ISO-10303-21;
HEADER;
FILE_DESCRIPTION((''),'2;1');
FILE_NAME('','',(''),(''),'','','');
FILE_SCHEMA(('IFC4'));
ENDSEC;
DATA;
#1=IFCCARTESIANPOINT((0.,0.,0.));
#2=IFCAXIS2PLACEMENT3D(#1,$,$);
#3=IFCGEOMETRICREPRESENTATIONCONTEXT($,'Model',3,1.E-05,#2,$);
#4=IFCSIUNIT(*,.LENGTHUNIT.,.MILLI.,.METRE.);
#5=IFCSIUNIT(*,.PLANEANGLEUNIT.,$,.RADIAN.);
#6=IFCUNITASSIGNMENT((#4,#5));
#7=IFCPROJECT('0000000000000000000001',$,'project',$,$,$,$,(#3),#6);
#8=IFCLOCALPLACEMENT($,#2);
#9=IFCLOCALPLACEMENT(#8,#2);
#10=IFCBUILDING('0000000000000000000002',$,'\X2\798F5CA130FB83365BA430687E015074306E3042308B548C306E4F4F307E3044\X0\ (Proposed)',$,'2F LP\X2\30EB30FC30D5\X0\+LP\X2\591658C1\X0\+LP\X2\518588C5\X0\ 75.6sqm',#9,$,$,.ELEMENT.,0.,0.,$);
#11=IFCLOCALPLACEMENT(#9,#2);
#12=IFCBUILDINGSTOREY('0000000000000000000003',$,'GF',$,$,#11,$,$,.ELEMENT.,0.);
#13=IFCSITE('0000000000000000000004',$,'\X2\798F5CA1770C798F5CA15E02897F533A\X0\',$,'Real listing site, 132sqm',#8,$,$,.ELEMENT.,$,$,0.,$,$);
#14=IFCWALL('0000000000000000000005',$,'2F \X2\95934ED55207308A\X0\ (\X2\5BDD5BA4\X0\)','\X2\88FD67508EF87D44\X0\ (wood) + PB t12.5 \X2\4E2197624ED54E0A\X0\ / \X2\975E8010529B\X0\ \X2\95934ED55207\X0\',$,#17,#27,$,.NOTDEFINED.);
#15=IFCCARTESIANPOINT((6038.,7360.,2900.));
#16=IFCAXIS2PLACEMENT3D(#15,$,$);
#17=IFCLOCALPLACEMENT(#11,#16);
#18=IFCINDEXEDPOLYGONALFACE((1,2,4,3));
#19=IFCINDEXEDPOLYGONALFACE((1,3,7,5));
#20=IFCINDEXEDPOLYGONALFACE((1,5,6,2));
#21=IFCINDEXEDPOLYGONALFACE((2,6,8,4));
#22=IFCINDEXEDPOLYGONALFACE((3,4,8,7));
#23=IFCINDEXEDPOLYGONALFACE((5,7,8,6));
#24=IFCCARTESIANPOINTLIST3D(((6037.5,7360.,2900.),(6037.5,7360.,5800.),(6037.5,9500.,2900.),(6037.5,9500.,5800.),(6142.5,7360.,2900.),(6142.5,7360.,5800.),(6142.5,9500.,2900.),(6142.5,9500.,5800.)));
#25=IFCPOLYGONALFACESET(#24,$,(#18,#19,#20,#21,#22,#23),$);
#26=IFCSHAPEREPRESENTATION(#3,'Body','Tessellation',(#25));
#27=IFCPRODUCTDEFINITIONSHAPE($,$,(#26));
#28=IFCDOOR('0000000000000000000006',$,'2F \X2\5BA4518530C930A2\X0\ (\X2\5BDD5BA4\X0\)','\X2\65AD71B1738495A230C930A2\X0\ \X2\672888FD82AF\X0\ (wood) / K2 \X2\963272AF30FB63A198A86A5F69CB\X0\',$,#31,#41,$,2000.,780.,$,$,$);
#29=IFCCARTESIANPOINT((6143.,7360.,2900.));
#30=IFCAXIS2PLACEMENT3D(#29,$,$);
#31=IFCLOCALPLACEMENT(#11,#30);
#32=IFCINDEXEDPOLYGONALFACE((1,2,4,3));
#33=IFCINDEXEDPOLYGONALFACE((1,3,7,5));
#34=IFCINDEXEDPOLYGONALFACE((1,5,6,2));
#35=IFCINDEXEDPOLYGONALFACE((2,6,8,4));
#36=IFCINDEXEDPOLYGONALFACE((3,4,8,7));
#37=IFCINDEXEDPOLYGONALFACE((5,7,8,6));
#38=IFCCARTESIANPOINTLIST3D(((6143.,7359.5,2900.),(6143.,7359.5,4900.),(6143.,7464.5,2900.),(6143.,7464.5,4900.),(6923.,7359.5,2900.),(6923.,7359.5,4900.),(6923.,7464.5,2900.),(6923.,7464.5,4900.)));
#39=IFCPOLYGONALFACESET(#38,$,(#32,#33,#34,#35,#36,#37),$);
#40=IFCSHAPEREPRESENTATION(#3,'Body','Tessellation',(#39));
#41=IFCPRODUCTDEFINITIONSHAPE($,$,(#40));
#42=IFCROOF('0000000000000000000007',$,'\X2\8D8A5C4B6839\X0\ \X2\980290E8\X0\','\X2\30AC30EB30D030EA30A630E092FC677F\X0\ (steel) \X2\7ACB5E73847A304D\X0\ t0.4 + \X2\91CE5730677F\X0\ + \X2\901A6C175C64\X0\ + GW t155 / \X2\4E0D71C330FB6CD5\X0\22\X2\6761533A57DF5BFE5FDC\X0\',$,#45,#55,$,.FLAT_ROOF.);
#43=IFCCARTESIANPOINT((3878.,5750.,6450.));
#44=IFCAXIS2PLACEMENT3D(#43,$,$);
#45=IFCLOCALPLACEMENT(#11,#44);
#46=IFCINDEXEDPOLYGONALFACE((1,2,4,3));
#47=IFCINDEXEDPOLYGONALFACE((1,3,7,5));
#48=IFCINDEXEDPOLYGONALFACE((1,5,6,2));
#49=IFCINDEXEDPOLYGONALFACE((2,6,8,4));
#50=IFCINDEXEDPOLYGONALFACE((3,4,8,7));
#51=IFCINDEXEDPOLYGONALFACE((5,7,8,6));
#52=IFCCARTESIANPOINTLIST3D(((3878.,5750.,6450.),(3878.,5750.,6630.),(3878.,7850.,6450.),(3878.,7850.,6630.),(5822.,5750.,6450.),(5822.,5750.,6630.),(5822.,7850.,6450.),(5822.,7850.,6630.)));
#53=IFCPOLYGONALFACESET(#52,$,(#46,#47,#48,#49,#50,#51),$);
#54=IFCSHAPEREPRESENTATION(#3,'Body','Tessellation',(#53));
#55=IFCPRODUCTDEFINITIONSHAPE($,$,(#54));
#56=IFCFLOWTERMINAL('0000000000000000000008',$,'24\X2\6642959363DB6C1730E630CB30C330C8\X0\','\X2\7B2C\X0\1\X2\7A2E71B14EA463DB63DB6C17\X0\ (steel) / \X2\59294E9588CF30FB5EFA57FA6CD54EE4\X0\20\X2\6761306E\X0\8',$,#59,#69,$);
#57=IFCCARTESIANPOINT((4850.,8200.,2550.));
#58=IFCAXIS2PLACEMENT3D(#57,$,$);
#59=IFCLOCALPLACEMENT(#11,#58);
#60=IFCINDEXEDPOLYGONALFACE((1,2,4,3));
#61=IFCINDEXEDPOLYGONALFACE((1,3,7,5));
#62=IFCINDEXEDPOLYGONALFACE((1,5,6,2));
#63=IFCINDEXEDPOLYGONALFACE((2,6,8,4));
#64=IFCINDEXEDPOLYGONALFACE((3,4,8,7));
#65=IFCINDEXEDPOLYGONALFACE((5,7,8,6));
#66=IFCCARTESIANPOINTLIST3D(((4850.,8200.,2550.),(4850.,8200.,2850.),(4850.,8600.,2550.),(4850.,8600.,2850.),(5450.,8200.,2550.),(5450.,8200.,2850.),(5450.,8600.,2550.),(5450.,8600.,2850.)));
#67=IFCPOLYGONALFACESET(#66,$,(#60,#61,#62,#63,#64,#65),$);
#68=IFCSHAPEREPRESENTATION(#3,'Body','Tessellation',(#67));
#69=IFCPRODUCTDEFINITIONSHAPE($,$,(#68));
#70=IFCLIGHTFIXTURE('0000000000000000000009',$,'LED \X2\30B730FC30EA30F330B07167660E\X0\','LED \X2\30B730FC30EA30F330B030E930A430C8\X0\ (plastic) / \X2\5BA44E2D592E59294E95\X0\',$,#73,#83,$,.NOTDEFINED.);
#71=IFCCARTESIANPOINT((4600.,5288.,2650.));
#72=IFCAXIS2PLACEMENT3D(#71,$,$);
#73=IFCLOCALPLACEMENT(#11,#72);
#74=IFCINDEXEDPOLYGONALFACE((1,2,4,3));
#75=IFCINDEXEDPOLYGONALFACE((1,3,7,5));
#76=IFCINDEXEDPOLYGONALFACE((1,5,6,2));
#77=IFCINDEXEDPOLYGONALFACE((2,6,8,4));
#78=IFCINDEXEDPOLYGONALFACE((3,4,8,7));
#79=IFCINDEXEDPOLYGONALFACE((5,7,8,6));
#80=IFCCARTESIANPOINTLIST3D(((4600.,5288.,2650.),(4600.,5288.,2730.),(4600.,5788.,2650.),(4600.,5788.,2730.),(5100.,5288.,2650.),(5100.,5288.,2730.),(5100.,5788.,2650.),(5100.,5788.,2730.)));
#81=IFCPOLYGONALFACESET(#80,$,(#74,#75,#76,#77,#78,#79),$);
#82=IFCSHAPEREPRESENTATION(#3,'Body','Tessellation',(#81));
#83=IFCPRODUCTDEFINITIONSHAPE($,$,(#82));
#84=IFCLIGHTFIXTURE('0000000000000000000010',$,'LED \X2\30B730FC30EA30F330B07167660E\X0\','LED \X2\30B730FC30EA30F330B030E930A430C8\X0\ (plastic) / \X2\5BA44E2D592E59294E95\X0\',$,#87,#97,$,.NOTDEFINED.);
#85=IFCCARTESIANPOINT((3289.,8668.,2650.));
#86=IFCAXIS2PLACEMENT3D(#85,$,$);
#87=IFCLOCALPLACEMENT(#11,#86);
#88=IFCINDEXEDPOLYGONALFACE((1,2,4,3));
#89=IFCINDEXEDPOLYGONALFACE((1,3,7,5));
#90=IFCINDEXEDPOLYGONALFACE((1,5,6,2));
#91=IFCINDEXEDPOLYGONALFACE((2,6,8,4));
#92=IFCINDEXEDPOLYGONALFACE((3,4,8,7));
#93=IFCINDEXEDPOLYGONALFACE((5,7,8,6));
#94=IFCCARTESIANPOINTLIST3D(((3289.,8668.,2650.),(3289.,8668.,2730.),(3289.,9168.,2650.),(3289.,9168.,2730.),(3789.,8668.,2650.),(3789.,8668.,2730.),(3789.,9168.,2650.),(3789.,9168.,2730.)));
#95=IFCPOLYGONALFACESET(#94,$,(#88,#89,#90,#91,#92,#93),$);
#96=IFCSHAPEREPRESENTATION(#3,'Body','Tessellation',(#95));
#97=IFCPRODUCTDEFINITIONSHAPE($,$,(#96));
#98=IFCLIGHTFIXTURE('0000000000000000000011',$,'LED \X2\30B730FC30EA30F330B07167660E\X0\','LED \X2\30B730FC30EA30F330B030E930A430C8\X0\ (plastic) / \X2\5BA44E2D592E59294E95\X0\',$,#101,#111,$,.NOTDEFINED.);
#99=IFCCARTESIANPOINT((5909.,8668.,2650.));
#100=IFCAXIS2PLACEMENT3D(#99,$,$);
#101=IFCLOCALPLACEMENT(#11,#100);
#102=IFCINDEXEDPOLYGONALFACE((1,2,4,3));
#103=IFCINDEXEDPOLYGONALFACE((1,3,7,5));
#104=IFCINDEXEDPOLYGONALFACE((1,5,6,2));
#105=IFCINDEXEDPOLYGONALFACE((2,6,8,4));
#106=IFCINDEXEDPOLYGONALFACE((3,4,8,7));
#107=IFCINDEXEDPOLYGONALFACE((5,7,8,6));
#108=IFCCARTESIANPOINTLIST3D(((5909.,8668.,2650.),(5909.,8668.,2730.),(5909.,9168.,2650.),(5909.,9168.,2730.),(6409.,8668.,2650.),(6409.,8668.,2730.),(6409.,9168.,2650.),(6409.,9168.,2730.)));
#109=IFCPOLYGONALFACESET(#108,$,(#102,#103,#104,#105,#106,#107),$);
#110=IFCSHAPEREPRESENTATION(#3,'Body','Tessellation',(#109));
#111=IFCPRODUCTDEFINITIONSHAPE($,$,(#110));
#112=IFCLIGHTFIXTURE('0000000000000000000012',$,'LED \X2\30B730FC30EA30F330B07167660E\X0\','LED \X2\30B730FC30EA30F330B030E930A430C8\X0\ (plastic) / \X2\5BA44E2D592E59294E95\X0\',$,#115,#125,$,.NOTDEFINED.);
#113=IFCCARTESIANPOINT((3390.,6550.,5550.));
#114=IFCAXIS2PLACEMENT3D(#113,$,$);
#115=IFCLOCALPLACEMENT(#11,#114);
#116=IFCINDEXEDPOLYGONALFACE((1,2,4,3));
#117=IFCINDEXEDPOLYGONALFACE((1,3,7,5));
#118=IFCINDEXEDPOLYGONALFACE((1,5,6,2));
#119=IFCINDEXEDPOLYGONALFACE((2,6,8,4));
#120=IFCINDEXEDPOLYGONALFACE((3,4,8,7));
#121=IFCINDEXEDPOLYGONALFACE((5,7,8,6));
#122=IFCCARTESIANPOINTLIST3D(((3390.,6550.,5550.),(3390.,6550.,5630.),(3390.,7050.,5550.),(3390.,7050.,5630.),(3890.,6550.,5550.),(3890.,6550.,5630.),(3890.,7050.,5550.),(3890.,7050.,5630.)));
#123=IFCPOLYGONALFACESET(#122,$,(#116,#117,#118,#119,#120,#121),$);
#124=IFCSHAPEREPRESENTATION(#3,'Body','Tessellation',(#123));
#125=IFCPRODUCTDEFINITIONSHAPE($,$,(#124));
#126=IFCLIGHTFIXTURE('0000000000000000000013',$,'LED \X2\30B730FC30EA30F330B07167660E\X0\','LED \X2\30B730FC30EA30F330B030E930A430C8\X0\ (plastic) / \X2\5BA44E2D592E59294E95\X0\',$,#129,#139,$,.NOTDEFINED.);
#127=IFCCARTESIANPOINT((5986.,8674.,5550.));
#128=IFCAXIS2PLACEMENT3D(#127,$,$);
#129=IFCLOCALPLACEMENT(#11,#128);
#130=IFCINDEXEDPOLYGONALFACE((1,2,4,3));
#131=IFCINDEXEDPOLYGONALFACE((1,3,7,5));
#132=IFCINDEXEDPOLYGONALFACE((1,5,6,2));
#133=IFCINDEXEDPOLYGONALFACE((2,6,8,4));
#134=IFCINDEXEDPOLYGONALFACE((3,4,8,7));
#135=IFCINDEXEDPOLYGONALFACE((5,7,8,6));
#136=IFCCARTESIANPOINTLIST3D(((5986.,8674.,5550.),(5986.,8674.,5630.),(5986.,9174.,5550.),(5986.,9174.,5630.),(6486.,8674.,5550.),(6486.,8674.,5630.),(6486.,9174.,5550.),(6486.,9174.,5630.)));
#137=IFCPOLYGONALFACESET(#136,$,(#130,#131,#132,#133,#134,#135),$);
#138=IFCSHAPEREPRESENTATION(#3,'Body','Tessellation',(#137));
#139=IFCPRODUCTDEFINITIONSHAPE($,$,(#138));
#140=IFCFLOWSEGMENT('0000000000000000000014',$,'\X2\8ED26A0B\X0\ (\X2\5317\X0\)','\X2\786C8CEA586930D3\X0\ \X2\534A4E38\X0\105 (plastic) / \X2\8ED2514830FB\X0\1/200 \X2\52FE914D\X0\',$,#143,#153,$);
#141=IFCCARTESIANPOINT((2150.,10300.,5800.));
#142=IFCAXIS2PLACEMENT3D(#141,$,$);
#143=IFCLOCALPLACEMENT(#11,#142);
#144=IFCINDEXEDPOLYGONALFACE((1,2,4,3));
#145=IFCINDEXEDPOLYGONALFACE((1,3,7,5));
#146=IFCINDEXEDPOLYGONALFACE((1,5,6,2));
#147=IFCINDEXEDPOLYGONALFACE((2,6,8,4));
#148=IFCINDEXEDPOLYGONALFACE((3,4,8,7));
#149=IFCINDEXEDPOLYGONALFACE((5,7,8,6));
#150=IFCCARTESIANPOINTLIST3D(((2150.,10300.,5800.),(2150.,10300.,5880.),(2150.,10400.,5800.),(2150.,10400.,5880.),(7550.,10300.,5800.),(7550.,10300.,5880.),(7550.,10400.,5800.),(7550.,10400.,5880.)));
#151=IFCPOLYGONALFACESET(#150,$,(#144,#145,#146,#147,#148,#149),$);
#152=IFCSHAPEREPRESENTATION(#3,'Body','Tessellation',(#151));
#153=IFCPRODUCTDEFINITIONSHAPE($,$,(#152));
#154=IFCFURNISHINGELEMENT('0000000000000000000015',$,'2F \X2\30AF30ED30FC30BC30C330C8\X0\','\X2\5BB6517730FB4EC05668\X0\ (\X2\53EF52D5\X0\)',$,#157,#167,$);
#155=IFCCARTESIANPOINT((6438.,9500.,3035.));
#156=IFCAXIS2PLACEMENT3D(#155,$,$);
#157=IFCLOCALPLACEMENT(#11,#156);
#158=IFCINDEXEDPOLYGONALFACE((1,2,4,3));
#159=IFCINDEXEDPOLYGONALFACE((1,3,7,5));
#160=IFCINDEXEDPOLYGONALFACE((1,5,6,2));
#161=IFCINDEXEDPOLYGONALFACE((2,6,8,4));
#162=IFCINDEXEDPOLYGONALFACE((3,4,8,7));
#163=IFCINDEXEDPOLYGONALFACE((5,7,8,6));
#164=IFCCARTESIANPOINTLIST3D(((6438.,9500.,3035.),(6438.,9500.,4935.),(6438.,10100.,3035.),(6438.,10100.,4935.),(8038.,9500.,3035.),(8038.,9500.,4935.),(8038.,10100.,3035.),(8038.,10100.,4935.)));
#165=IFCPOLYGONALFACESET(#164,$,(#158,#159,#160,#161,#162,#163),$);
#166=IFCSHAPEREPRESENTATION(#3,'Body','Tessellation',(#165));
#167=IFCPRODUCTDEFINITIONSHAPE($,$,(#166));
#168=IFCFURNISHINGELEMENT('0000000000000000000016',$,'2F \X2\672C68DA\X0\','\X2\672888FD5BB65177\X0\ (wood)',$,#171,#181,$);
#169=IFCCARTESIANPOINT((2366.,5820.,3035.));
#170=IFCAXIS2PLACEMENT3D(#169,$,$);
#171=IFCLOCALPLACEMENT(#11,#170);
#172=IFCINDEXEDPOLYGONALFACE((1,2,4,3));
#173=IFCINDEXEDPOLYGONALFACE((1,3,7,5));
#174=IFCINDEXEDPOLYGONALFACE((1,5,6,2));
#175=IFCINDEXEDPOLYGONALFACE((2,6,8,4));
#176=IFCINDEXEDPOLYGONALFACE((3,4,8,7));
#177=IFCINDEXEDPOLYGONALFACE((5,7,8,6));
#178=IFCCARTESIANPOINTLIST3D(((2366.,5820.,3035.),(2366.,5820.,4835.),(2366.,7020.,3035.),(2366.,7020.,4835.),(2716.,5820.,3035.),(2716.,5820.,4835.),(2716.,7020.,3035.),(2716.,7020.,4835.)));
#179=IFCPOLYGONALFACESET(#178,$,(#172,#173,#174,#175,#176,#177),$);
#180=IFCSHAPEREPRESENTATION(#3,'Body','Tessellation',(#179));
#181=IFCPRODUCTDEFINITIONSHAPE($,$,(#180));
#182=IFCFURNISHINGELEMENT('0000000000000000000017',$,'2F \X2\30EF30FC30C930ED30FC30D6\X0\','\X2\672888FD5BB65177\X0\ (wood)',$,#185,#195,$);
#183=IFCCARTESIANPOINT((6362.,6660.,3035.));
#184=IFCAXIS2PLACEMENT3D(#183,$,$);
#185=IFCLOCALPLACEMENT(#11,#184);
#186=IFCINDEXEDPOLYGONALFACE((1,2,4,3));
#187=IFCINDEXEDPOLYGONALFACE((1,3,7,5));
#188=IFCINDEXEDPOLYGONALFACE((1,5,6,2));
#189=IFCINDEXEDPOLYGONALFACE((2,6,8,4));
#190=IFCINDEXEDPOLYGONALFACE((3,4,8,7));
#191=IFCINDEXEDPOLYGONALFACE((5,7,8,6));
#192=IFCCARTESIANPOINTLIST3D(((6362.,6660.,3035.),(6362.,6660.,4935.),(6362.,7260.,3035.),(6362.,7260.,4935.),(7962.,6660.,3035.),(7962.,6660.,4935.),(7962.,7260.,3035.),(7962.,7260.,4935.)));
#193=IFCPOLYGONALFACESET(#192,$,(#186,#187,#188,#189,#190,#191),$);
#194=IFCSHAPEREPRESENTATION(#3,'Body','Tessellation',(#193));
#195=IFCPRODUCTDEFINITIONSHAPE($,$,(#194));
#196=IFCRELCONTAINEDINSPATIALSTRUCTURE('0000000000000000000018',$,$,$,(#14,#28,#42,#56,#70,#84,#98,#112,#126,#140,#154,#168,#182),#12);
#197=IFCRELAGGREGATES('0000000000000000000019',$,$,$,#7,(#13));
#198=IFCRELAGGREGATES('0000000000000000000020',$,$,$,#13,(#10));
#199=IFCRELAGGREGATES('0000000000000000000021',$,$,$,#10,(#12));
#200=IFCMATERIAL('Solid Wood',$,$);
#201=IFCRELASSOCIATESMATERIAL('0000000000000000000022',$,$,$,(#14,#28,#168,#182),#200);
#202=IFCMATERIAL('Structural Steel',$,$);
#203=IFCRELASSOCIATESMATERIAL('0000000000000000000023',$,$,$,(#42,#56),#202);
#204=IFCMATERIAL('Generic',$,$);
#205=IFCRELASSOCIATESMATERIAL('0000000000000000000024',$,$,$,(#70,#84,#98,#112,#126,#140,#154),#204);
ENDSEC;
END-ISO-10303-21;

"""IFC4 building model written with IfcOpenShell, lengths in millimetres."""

from ifc_helpers import new_model, si_unit, frame, frame_2d, origin, place, context, project, spatial, rectangle, extrude, material, element, save


model = new_model("IFC4")

# Units and contexts
model_context = context("Model", 3, precision=1e-05, world=origin())
ifc_project = project(units=[si_unit("LENGTHUNIT", "METRE", prefix="MILLI"), si_unit("PLANEANGLEUNIT", "RADIAN")], contexts=[model_context])

# Site, building, storey
site_placement = place(None, origin())
site = spatial("IfcSite", under=ifc_project, at=site_placement, Name="福岡県福岡市西区", ObjectType="Real listing site, 132sqm", CompositionType="ELEMENT", RefElevation=0.0)
building_placement = place(site_placement, origin())
building = spatial("IfcBuilding", under=site, at=building_placement, Name="福岡・茶室と縁側のある和の住まい (Proposed)", ObjectType="2F LPルーフ+LP外壁+LP内装 75.6sqm", CompositionType="ELEMENT", ElevationOfRefHeight=0.0, ElevationOfTerrain=0.0)
storey_placement = place(building_placement, origin())
storey = spatial("IfcBuildingStorey", under=building, at=storey_placement, Name="GF", CompositionType="ELEMENT", Elevation=0.0)

# Shared definitions
ifc_material_1 = material(Name="Solid Wood")

# Wall
wall_1_placement = place(storey_placement, frame((6038.0, 7360.0, 2900.0)))
element("IfcWall", 1, at=wall_1_placement, inside=storey, material=ifc_material_1, Name="2F 間仕切り (寝室)", Description="製材軸組 (wood) + PB t12.5 両面仕上 / 非耐力 間仕切", PredefinedType="NOTDEFINED", context=model_context, shape_type="SweptSolid", body=[
    extrude(rectangle(XDim=105.0, YDim=2140.0, at=frame_2d((52.0, 1070.0))), frame((6038.0, 7360.0, 2900.0)), (0.0, 0.0, 1.0), 2900.0),
])

# Door
door_placement = place(storey_placement, frame((6143.0, 7360.0, 2900.0)))
element("IfcDoor", 2, at=door_placement, inside=storey, material=ifc_material_1, Name="2F 室内ドア (寝室)", Description="断熱玄関ドア 木製芯 (wood) / K2 防犯・採風機構", OverallHeight=2000.0, OverallWidth=780.0, context=model_context, shape_type="SweptSolid", body=[
    extrude(rectangle(XDim=780.0, YDim=105.0, at=frame_2d((390.0, 52.0))), frame((6143.0, 7360.0, 2900.0)), (0.0, 0.0, 1.0), 2000.0),
])

# Roof
ifc_material_2 = material(Name="Structural Steel")
roof_placement = place(storey_placement, frame((3878.0, 5750.0, 6450.0)))
element("IfcRoof", 3, at=roof_placement, inside=storey, material=ifc_material_2, Name="越屋根 頂部", Description="ガルバリウム鋼板 (steel) 立平葺き t0.4 + 野地板 + 通気層 + GW t155 / 不燃・法22条区域対応", PredefinedType="FLAT_ROOF", context=model_context, shape_type="SweptSolid", body=[
    extrude(rectangle(XDim=1944.0, YDim=2100.0, at=frame_2d((972.0, 1050.0))), frame((3878.0, 5750.0, 6450.0)), (0.0, 0.0, 1.0), 180.0),
])

# Flow terminal
flow_terminal_placement = place(storey_placement, frame((4850.0, 8200.0, 2550.0)))
element("IfcFlowTerminal", 4, at=flow_terminal_placement, inside=storey, material=ifc_material_2, Name="24時間換気ユニット", Description="第1種熱交換換気 (steel) / 天井裏・建基法令20条の8", context=model_context, shape_type="SweptSolid", body=[
    extrude(rectangle(XDim=600.0, YDim=400.0, at=frame_2d((300.0, 200.0))), frame((4850.0, 8200.0, 2550.0)), (0.0, 0.0, 1.0), 300.0),
])

# Light fixtures
ifc_material_3 = material(Name="Generic")
light_fixture_1_placement = place(storey_placement, frame((4600.0, 5288.0, 2650.0)))
element("IfcLightFixture", 5, at=light_fixture_1_placement, inside=storey, material=ifc_material_3, Name="LED シーリング照明", Description="LED シーリングライト (plastic) / 室中央天井", PredefinedType="NOTDEFINED", context=model_context, shape_type="SweptSolid", body=[
    extrude(rectangle(XDim=500.0, YDim=500.0, at=frame_2d((250.0, 250.0))), frame((4600.0, 5288.0, 2650.0)), (0.0, 0.0, 1.0), 80.0),
])
light_fixture_2_placement = place(storey_placement, frame((3289.0, 8668.0, 2650.0)))
element("IfcLightFixture", 6, at=light_fixture_2_placement, inside=storey, material=ifc_material_3, Name="LED シーリング照明", Description="LED シーリングライト (plastic) / 室中央天井", PredefinedType="NOTDEFINED", context=model_context, shape_type="SweptSolid", body=[
    extrude(rectangle(XDim=500.0, YDim=500.0, at=frame_2d((250.0, 250.0))), frame((3289.0, 8668.0, 2650.0)), (0.0, 0.0, 1.0), 80.0),
])
light_fixture_3_placement = place(storey_placement, frame((5909.0, 8668.0, 2650.0)))
element("IfcLightFixture", 7, at=light_fixture_3_placement, inside=storey, material=ifc_material_3, Name="LED シーリング照明", Description="LED シーリングライト (plastic) / 室中央天井", PredefinedType="NOTDEFINED", context=model_context, shape_type="SweptSolid", body=[
    extrude(rectangle(XDim=500.0, YDim=500.0, at=frame_2d((250.0, 250.0))), frame((5909.0, 8668.0, 2650.0)), (0.0, 0.0, 1.0), 80.0),
])
light_fixture_4_placement = place(storey_placement, frame((3390.0, 6550.0, 5550.0)))
element("IfcLightFixture", 8, at=light_fixture_4_placement, inside=storey, material=ifc_material_3, Name="LED シーリング照明", Description="LED シーリングライト (plastic) / 室中央天井", PredefinedType="NOTDEFINED", context=model_context, shape_type="SweptSolid", body=[
    extrude(rectangle(XDim=500.0, YDim=500.0, at=frame_2d((250.0, 250.0))), frame((3390.0, 6550.0, 5550.0)), (0.0, 0.0, 1.0), 80.0),
])
light_fixture_5_placement = place(storey_placement, frame((5986.0, 8674.0, 5550.0)))
element("IfcLightFixture", 9, at=light_fixture_5_placement, inside=storey, material=ifc_material_3, Name="LED シーリング照明", Description="LED シーリングライト (plastic) / 室中央天井", PredefinedType="NOTDEFINED", context=model_context, shape_type="SweptSolid", body=[
    extrude(rectangle(XDim=500.0, YDim=500.0, at=frame_2d((250.0, 250.0))), frame((5986.0, 8674.0, 5550.0)), (0.0, 0.0, 1.0), 80.0),
])

# Flow segment
flow_segment_placement = place(storey_placement, frame((2150.0, 10300.0, 5800.0)))
element("IfcFlowSegment", 10, at=flow_segment_placement, inside=storey, material=ifc_material_3, Name="軒樋 (北)", Description="硬質塩ビ 半丸105 (plastic) / 軒先・1/200 勾配", context=model_context, shape_type="SweptSolid", body=[
    extrude(rectangle(XDim=5400.0, YDim=100.0, at=frame_2d((2700.0, 50.0))), frame((2150.0, 10300.0, 5800.0)), (0.0, 0.0, 1.0), 80.0),
])

# Furnishing elements
furnishing_1_placement = place(storey_placement, frame((6438.0, 9500.0, 3035.0)))
element("IfcFurnishingElement", 11, at=furnishing_1_placement, inside=storey, material=ifc_material_3, Name="2F クローゼット", Description="家具・什器 (可動)", context=model_context, shape_type="SweptSolid", body=[
    extrude(rectangle(XDim=1600.0, YDim=600.0, at=frame_2d((800.0, 300.0))), frame((6438.0, 9500.0, 3035.0)), (0.0, 0.0, 1.0), 1900.0),
])
furnishing_2_placement = place(storey_placement, frame((2366.0, 5820.0, 3035.0)))
element("IfcFurnishingElement", 12, at=furnishing_2_placement, inside=storey, material=ifc_material_1, Name="2F 本棚", Description="木製家具 (wood)", context=model_context, shape_type="SweptSolid", body=[
    extrude(rectangle(XDim=350.0, YDim=1200.0, at=frame_2d((175.0, 600.0))), frame((2366.0, 5820.0, 3035.0)), (0.0, 0.0, 1.0), 1800.0),
])
furnishing_3_placement = place(storey_placement, frame((6362.0, 6660.0, 3035.0)))
element("IfcFurnishingElement", 13, at=furnishing_3_placement, inside=storey, material=ifc_material_1, Name="2F ワードローブ", Description="木製家具 (wood)", context=model_context, shape_type="SweptSolid", body=[
    extrude(rectangle(XDim=1600.0, YDim=600.0, at=frame_2d((800.0, 300.0))), frame((6362.0, 6660.0, 3035.0)), (0.0, 0.0, 1.0), 1900.0),
])

save(model, "model.ifc")
